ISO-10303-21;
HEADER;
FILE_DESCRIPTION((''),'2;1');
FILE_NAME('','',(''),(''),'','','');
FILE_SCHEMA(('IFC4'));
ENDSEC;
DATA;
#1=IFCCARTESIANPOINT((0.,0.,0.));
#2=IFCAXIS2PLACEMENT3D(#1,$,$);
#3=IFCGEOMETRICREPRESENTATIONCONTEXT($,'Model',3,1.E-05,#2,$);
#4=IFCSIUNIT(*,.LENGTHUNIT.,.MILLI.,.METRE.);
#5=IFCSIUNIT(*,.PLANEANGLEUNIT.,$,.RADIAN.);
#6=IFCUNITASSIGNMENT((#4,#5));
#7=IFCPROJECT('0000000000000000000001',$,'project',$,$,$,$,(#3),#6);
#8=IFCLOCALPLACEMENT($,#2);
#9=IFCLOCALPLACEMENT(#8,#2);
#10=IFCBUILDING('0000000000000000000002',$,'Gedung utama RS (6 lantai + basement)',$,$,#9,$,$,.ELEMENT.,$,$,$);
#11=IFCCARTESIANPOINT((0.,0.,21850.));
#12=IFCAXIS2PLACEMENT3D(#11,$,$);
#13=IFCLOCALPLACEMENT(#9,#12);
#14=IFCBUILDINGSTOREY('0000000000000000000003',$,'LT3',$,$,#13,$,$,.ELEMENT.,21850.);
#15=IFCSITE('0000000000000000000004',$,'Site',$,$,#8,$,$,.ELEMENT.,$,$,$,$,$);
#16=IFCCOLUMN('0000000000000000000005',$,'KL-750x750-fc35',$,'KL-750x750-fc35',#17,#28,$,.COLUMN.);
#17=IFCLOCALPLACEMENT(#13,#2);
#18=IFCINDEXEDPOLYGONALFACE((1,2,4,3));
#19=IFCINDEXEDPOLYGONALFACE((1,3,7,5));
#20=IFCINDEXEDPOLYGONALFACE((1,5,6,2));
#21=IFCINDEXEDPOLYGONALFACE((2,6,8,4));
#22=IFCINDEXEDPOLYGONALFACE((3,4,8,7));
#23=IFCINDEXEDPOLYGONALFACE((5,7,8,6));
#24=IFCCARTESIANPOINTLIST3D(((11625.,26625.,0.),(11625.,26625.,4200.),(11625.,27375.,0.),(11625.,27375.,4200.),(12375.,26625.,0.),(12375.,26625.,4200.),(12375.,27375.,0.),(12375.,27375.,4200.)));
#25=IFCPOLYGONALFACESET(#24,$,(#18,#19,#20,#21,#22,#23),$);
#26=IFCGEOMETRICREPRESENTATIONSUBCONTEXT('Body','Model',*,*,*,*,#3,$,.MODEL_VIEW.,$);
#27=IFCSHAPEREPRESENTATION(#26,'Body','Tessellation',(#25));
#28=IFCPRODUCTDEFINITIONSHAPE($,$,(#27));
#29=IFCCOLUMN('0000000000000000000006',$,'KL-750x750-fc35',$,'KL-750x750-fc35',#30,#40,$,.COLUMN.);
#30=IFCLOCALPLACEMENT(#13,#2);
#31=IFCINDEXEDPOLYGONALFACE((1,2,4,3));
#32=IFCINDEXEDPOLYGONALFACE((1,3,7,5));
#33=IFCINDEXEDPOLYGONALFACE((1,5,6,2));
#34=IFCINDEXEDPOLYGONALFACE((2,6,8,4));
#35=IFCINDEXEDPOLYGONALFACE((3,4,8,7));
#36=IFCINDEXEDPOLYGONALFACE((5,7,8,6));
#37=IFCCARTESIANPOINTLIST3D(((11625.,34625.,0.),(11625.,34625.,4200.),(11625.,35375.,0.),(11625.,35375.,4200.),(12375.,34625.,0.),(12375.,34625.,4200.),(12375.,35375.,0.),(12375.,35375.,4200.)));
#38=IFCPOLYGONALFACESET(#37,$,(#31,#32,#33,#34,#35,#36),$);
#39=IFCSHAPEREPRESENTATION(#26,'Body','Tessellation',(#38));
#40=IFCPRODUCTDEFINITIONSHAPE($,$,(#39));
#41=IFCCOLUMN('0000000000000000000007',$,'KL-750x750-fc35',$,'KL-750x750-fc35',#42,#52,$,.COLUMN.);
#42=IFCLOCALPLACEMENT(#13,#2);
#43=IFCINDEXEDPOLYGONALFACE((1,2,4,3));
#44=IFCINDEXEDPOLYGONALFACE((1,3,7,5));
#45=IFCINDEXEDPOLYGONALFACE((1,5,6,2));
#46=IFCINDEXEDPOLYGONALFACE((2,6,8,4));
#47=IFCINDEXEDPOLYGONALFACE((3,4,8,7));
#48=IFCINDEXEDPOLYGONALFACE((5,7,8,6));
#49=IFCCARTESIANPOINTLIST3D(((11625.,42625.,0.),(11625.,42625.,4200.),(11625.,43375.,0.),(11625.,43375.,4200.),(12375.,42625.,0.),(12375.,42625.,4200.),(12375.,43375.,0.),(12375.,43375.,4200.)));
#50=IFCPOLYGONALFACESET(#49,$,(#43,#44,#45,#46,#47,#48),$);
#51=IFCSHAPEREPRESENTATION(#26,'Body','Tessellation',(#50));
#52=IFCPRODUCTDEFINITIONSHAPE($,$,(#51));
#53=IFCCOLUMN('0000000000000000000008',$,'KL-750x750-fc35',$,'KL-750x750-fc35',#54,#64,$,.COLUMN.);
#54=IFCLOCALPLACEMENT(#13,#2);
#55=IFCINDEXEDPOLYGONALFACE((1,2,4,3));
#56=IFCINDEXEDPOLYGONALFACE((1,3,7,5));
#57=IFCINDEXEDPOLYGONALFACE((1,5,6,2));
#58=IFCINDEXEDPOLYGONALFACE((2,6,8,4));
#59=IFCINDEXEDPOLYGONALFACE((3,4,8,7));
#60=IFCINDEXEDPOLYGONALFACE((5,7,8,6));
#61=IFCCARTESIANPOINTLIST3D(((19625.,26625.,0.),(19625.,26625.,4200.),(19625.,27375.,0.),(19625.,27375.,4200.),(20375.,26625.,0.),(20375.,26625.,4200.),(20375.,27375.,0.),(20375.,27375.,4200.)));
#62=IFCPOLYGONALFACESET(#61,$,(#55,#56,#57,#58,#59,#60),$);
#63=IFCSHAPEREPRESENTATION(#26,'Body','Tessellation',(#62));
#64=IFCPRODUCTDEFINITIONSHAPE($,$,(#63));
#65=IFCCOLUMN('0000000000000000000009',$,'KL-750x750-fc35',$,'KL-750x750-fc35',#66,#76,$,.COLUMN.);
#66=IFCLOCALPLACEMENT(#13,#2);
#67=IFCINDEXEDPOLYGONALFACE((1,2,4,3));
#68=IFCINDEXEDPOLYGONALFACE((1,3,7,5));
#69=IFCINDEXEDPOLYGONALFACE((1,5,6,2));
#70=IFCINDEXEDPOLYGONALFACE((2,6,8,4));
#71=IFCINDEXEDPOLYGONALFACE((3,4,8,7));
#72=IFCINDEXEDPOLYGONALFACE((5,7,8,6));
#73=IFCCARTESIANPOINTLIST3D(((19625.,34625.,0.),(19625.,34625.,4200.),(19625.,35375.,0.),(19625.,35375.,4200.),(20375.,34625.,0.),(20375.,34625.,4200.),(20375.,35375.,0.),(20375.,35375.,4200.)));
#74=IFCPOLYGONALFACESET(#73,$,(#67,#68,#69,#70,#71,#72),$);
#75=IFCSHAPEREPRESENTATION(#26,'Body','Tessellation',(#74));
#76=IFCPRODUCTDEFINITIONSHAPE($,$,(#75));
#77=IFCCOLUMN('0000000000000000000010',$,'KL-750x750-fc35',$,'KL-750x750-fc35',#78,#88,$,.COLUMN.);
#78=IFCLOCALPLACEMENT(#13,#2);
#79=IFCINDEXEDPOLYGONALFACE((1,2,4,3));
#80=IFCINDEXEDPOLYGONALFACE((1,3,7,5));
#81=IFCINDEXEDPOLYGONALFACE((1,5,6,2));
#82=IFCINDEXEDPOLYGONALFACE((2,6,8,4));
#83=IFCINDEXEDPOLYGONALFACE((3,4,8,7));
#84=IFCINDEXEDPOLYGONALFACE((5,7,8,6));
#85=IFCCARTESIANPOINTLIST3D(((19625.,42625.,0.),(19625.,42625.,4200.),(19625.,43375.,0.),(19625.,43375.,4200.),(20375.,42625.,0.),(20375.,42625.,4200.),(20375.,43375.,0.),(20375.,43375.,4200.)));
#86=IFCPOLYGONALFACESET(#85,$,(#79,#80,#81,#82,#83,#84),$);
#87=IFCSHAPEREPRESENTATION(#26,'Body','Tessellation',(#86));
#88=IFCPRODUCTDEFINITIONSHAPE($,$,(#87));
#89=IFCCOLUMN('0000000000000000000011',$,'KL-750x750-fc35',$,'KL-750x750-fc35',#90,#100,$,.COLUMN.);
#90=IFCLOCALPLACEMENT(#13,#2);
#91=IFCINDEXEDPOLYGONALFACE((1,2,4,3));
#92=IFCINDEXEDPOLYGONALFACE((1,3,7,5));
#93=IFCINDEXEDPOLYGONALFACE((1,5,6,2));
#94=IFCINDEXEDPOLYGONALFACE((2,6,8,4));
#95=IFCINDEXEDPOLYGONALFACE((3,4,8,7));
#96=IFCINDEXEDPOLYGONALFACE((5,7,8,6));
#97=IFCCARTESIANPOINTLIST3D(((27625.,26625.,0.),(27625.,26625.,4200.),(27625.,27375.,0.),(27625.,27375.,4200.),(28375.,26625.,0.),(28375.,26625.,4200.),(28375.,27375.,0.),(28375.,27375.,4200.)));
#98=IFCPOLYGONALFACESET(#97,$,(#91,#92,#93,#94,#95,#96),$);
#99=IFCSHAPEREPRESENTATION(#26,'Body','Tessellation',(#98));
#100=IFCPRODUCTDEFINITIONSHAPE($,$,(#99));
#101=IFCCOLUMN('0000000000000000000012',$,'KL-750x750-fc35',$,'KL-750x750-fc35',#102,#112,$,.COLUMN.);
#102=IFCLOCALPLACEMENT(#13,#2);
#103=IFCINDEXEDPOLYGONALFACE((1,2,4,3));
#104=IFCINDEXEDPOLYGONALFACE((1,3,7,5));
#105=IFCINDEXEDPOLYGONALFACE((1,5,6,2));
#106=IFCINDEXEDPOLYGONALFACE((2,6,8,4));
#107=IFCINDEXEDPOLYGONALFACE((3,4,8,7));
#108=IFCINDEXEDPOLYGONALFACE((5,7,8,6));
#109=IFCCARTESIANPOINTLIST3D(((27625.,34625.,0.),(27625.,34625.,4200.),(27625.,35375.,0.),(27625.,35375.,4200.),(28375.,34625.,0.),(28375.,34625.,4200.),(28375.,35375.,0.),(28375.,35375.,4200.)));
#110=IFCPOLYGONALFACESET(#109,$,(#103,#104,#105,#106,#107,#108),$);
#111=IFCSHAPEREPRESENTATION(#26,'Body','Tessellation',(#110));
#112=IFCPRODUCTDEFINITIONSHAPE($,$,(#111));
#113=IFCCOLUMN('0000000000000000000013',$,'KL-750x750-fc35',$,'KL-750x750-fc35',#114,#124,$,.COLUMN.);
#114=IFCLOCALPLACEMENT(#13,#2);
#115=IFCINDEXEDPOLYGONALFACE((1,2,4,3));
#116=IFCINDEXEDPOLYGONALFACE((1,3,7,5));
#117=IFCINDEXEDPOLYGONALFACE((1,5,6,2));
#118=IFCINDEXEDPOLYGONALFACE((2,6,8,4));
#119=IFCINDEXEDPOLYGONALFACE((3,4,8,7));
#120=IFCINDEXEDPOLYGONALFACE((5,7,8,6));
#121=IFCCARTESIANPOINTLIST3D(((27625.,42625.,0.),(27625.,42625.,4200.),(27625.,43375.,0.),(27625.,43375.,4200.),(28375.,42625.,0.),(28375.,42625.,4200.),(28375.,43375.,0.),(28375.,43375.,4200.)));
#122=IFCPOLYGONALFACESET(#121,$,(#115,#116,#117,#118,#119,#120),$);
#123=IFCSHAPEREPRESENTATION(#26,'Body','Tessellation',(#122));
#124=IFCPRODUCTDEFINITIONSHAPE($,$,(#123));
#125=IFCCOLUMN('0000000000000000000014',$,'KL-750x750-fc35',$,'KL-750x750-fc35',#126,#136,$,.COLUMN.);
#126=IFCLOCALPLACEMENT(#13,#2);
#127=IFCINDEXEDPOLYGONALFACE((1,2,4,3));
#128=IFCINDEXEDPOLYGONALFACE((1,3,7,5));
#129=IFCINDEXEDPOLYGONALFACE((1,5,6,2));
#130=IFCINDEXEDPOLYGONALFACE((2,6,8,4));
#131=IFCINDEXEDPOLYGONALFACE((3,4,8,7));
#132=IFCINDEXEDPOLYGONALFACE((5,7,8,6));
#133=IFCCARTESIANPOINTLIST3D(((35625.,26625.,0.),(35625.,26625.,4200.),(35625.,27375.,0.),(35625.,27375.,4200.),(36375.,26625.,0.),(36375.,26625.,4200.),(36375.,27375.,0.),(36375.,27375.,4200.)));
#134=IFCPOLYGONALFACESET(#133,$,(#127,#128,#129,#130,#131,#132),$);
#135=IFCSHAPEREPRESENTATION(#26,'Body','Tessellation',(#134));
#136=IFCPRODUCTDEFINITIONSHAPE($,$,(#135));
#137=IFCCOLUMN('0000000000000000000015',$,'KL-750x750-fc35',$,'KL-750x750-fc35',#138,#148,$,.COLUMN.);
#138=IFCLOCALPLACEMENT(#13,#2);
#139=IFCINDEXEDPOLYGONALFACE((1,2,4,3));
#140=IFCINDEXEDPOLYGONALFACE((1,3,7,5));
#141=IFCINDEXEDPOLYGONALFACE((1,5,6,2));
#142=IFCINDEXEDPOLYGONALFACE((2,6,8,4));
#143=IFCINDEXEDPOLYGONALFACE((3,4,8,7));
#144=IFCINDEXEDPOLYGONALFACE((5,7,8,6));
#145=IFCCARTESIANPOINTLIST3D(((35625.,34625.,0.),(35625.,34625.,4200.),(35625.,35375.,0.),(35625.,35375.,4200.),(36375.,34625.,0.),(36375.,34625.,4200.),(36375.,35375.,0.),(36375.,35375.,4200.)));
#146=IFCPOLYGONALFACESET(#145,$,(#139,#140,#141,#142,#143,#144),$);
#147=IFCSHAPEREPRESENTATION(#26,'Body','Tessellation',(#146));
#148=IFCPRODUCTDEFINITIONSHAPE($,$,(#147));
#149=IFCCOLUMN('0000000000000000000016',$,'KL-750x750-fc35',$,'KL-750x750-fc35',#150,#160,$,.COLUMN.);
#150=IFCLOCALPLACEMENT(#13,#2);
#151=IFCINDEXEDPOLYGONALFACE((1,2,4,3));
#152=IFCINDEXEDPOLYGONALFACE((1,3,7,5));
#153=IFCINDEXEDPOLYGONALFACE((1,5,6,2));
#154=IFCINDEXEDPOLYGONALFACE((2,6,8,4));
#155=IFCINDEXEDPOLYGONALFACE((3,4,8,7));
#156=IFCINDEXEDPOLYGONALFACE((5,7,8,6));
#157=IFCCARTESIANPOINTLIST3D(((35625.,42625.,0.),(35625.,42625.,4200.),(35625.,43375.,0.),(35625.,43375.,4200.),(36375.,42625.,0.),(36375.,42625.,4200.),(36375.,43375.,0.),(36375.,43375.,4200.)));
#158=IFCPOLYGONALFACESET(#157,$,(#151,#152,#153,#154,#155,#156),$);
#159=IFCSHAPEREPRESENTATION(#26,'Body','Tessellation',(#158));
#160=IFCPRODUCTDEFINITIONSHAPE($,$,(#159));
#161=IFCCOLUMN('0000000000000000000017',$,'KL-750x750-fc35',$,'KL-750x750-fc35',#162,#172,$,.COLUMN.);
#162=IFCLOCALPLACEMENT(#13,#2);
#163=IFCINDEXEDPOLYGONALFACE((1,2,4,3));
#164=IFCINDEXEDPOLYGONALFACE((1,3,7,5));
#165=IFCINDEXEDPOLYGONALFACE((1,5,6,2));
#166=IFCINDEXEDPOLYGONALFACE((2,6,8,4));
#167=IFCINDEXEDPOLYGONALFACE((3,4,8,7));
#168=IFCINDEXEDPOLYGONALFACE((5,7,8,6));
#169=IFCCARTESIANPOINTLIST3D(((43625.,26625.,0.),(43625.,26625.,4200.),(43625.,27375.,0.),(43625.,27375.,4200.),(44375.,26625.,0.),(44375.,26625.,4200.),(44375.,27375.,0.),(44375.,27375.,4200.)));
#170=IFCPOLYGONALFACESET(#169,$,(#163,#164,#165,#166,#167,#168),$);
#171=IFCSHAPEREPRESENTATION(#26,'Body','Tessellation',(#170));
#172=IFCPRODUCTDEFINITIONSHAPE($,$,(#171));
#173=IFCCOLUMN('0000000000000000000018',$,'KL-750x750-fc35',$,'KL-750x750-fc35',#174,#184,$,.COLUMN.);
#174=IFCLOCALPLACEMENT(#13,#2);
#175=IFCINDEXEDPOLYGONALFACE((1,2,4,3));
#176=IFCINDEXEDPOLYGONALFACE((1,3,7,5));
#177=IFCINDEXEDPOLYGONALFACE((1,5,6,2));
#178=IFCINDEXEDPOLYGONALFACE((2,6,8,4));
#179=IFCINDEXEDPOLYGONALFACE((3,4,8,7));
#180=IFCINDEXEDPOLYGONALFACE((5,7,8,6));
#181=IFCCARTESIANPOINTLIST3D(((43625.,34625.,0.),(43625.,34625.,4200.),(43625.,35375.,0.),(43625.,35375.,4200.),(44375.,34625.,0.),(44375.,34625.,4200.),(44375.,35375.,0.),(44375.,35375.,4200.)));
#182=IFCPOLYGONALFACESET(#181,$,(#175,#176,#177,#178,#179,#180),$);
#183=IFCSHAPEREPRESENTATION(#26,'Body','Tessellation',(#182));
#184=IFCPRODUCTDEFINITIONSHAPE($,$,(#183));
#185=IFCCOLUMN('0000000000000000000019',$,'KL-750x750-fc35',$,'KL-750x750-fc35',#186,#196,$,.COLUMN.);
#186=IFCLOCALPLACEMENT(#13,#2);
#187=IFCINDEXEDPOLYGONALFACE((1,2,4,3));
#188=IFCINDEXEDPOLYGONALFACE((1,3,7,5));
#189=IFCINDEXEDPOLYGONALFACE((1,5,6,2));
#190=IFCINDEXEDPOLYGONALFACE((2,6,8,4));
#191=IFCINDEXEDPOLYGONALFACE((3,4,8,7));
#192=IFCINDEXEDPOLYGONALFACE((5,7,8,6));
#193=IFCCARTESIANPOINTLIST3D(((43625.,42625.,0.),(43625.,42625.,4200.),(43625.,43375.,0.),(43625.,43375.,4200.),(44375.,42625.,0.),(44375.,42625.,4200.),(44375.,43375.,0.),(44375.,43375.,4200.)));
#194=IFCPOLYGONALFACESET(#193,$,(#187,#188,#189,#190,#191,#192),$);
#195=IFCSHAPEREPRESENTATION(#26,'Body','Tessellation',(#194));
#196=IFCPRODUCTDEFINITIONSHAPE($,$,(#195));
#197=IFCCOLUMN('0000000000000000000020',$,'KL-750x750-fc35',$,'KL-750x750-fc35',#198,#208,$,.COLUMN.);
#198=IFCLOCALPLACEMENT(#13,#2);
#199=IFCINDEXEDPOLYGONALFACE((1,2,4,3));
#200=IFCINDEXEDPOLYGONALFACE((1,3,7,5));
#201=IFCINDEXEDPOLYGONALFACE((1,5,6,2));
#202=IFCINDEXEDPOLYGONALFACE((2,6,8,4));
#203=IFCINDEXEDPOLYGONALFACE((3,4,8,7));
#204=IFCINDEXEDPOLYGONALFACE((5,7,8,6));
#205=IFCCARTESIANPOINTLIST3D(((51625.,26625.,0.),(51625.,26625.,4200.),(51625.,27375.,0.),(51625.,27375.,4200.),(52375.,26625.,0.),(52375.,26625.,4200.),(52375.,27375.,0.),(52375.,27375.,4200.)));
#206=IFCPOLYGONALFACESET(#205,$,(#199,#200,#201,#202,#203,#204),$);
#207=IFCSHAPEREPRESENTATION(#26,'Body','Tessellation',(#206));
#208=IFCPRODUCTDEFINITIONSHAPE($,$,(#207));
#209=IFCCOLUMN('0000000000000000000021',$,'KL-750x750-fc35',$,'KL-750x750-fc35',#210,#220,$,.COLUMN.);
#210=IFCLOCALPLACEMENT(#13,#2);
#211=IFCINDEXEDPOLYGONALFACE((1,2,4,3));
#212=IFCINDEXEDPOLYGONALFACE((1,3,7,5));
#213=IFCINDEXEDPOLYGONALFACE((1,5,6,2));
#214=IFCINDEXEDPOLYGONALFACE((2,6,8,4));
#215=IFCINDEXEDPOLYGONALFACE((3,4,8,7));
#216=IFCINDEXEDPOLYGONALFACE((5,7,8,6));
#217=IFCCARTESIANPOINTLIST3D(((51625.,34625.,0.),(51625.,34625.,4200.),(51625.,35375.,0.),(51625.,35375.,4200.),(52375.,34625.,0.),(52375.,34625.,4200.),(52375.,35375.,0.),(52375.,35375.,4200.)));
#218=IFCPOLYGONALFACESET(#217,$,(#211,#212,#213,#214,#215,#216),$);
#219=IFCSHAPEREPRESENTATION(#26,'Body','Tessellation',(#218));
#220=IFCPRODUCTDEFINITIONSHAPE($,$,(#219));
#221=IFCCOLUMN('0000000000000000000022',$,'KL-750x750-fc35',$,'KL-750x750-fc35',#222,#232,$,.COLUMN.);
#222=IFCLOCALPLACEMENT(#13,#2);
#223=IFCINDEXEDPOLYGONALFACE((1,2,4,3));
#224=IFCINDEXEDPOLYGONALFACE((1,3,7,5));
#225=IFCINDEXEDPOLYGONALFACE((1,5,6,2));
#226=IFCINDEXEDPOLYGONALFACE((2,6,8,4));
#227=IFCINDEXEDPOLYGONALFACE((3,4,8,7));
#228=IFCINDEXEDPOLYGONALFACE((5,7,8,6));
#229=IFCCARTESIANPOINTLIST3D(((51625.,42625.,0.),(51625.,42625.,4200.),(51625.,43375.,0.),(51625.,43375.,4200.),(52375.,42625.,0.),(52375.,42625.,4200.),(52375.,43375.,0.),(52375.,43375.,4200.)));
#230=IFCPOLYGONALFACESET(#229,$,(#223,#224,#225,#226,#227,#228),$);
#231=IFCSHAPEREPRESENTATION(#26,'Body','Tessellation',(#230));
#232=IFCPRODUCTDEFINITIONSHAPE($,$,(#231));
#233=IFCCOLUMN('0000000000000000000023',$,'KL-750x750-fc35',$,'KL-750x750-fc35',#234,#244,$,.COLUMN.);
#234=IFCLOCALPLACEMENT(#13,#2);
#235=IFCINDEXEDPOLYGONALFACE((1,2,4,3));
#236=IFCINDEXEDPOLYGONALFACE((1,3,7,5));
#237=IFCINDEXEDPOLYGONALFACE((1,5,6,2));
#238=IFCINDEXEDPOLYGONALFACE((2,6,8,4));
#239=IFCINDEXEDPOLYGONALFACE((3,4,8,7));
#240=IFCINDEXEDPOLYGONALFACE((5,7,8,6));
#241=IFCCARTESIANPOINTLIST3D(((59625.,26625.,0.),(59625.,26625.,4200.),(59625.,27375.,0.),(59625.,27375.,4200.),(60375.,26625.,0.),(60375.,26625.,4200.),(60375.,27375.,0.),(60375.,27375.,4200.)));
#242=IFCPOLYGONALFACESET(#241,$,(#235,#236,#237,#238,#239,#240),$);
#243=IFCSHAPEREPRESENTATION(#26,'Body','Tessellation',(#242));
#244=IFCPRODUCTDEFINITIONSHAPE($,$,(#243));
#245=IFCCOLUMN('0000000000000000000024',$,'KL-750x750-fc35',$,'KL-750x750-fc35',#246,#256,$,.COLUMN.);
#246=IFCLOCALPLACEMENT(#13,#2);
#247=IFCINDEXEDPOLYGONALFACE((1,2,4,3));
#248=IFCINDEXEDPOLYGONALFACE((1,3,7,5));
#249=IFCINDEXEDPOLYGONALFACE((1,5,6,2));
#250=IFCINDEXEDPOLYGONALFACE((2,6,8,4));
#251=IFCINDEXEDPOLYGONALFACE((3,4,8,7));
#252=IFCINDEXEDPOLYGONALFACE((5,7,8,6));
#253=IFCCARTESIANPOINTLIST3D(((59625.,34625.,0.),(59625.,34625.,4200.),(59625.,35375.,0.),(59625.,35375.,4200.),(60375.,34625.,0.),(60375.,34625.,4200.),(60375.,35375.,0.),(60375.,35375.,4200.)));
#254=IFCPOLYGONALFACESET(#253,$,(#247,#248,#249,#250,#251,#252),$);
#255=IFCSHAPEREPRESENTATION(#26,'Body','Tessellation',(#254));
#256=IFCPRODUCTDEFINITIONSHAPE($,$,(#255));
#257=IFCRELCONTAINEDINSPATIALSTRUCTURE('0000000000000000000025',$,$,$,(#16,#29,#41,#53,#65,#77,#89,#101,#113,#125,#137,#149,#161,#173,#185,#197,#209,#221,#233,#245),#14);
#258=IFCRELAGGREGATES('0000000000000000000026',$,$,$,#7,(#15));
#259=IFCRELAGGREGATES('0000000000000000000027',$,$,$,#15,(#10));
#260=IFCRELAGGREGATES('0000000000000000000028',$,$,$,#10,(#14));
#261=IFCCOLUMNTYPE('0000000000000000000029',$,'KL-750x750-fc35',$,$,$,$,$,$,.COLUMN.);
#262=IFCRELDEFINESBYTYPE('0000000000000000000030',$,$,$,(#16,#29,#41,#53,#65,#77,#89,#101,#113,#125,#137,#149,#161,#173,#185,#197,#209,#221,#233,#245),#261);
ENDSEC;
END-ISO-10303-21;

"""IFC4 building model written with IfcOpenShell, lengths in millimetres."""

from ifc_helpers import new_model, si_unit, frame, origin, origin_2d, place, context, subcontext, project, spatial, rectangle, extrude, material_profile, profile_set, profile_usage, type_object, element, save


model = new_model("IFC4")

# Units and contexts
model_context = context("Model", 3, precision=1e-05, world=origin())
body_context = subcontext(model_context, "Body", "Model", "MODEL_VIEW")
ifc_project = project(units=[si_unit("LENGTHUNIT", "METRE", prefix="MILLI"), si_unit("PLANEANGLEUNIT", "RADIAN")], contexts=[model_context])

# Site, building, storey
site_placement = place(None, origin())
site = spatial("IfcSite", under=ifc_project, at=site_placement, Name="Site", CompositionType="ELEMENT")
building_placement = place(site_placement, origin())
building = spatial("IfcBuilding", under=site, at=building_placement, Name="Gedung utama RS (6 lantai + basement)", CompositionType="ELEMENT")
storey_placement = place(building_placement, frame((0.0, 0.0, 21850.0)))
storey = spatial("IfcBuildingStorey", under=building, at=storey_placement, Name="LT3", CompositionType="ELEMENT", Elevation=21850.0)

# Columns
ifc_material_profile_1 = material_profile(None, rectangle(XDim=750.0, YDim=750.0, at=origin_2d()), Name="KL-750x750-fc35")
ifc_profile_set_1 = profile_set([ifc_material_profile_1], Name="KL-750x750-fc35")
ifc_profile_usage_1 = profile_usage(ifc_profile_set_1, cardinal=5)
column_type = type_object("IfcColumnType", Name="KL-750x750-fc35", PredefinedType="COLUMN", material=ifc_profile_set_1)
for number, where, z_axis, x_axis, name in (
    (1, (12000.0, 27000.0, 0.0), (0.0, 0.0, 1.0), (1.0, 0.0, 0.0), "KL-750x750-fc35"),
    (2, (12000.0, 35000.0, 0.0), (0.0, 0.0, 1.0), (1.0, 0.0, 0.0), "KL-750x750-fc35"),
    (3, (12000.0, 43000.0, 0.0), (0.0, 0.0, 1.0), (1.0, 0.0, 0.0), "KL-750x750-fc35"),
    (4, (20000.0, 27000.0, 0.0), (0.0, 0.0, 1.0), (1.0, 0.0, 0.0), "KL-750x750-fc35"),
    (5, (20000.0, 35000.0, 0.0), (0.0, 0.0, 1.0), (1.0, 0.0, 0.0), "KL-750x750-fc35"),
    (6, (20000.0, 43000.0, 0.0), (0.0, 0.0, 1.0), (1.0, 0.0, 0.0), "KL-750x750-fc35"),
    (7, (28000.0, 27000.0, 0.0), (0.0, 0.0, 1.0), (1.0, 0.0, 0.0), "KL-750x750-fc35"),
    (8, (28000.0, 35000.0, 0.0), (0.0, 0.0, 1.0), (1.0, 0.0, 0.0), "KL-750x750-fc35"),
    (9, (28000.0, 43000.0, 0.0), (0.0, 0.0, 1.0), (1.0, 0.0, 0.0), "KL-750x750-fc35"),
    (10, (36000.0, 27000.0, 0.0), (0.0, 0.0, 1.0), (1.0, 0.0, 0.0), "KL-750x750-fc35"),
    (11, (36000.0, 35000.0, 0.0), (0.0, 0.0, 1.0), (1.0, 0.0, 0.0), "KL-750x750-fc35"),
    (12, (36000.0, 43000.0, 0.0), (0.0, 0.0, 1.0), (1.0, 0.0, 0.0), "KL-750x750-fc35"),
    (13, (44000.0, 27000.0, 0.0), (0.0, 0.0, 1.0), (1.0, 0.0, 0.0), "KL-750x750-fc35"),
    (14, (44000.0, 35000.0, 0.0), (0.0, 0.0, 1.0), (1.0, 0.0, 0.0), "KL-750x750-fc35"),
    (15, (44000.0, 43000.0, 0.0), (0.0, 0.0, 1.0), (1.0, 0.0, 0.0), "KL-750x750-fc35"),
    (16, (52000.0, 27000.0, 0.0), (0.0, 0.0, 1.0), (1.0, 0.0, 0.0), "KL-750x750-fc35"),
    (17, (52000.0, 35000.0, 0.0), (0.0, 0.0, 1.0), (1.0, 0.0, 0.0), "KL-750x750-fc35"),
    (18, (52000.0, 43000.0, 0.0), (0.0, 0.0, 1.0), (1.0, 0.0, 0.0), "KL-750x750-fc35"),
    (19, (60000.0, 27000.0, 0.0), (0.0, 0.0, 1.0), (1.0, 0.0, 0.0), "KL-750x750-fc35"),
    (20, (60000.0, 35000.0, 0.0), (0.0, 0.0, 1.0), (1.0, 0.0, 0.0), "KL-750x750-fc35"),
):
    element("IfcColumn", number, at=place(storey_placement, frame(where, z_axis=z_axis, x_axis=x_axis)), inside=storey, type_object=column_type, material=ifc_profile_usage_1, Name=name, ObjectType="KL-750x750-fc35", PredefinedType="COLUMN", context=body_context, shape_type="SweptSolid", body=[
        extrude(rectangle(XDim=750.0, YDim=750.0, at=origin_2d()), origin(), (0.0, 0.0, 1.0), 4200.0),
    ])

save(model, "model.ifc")
